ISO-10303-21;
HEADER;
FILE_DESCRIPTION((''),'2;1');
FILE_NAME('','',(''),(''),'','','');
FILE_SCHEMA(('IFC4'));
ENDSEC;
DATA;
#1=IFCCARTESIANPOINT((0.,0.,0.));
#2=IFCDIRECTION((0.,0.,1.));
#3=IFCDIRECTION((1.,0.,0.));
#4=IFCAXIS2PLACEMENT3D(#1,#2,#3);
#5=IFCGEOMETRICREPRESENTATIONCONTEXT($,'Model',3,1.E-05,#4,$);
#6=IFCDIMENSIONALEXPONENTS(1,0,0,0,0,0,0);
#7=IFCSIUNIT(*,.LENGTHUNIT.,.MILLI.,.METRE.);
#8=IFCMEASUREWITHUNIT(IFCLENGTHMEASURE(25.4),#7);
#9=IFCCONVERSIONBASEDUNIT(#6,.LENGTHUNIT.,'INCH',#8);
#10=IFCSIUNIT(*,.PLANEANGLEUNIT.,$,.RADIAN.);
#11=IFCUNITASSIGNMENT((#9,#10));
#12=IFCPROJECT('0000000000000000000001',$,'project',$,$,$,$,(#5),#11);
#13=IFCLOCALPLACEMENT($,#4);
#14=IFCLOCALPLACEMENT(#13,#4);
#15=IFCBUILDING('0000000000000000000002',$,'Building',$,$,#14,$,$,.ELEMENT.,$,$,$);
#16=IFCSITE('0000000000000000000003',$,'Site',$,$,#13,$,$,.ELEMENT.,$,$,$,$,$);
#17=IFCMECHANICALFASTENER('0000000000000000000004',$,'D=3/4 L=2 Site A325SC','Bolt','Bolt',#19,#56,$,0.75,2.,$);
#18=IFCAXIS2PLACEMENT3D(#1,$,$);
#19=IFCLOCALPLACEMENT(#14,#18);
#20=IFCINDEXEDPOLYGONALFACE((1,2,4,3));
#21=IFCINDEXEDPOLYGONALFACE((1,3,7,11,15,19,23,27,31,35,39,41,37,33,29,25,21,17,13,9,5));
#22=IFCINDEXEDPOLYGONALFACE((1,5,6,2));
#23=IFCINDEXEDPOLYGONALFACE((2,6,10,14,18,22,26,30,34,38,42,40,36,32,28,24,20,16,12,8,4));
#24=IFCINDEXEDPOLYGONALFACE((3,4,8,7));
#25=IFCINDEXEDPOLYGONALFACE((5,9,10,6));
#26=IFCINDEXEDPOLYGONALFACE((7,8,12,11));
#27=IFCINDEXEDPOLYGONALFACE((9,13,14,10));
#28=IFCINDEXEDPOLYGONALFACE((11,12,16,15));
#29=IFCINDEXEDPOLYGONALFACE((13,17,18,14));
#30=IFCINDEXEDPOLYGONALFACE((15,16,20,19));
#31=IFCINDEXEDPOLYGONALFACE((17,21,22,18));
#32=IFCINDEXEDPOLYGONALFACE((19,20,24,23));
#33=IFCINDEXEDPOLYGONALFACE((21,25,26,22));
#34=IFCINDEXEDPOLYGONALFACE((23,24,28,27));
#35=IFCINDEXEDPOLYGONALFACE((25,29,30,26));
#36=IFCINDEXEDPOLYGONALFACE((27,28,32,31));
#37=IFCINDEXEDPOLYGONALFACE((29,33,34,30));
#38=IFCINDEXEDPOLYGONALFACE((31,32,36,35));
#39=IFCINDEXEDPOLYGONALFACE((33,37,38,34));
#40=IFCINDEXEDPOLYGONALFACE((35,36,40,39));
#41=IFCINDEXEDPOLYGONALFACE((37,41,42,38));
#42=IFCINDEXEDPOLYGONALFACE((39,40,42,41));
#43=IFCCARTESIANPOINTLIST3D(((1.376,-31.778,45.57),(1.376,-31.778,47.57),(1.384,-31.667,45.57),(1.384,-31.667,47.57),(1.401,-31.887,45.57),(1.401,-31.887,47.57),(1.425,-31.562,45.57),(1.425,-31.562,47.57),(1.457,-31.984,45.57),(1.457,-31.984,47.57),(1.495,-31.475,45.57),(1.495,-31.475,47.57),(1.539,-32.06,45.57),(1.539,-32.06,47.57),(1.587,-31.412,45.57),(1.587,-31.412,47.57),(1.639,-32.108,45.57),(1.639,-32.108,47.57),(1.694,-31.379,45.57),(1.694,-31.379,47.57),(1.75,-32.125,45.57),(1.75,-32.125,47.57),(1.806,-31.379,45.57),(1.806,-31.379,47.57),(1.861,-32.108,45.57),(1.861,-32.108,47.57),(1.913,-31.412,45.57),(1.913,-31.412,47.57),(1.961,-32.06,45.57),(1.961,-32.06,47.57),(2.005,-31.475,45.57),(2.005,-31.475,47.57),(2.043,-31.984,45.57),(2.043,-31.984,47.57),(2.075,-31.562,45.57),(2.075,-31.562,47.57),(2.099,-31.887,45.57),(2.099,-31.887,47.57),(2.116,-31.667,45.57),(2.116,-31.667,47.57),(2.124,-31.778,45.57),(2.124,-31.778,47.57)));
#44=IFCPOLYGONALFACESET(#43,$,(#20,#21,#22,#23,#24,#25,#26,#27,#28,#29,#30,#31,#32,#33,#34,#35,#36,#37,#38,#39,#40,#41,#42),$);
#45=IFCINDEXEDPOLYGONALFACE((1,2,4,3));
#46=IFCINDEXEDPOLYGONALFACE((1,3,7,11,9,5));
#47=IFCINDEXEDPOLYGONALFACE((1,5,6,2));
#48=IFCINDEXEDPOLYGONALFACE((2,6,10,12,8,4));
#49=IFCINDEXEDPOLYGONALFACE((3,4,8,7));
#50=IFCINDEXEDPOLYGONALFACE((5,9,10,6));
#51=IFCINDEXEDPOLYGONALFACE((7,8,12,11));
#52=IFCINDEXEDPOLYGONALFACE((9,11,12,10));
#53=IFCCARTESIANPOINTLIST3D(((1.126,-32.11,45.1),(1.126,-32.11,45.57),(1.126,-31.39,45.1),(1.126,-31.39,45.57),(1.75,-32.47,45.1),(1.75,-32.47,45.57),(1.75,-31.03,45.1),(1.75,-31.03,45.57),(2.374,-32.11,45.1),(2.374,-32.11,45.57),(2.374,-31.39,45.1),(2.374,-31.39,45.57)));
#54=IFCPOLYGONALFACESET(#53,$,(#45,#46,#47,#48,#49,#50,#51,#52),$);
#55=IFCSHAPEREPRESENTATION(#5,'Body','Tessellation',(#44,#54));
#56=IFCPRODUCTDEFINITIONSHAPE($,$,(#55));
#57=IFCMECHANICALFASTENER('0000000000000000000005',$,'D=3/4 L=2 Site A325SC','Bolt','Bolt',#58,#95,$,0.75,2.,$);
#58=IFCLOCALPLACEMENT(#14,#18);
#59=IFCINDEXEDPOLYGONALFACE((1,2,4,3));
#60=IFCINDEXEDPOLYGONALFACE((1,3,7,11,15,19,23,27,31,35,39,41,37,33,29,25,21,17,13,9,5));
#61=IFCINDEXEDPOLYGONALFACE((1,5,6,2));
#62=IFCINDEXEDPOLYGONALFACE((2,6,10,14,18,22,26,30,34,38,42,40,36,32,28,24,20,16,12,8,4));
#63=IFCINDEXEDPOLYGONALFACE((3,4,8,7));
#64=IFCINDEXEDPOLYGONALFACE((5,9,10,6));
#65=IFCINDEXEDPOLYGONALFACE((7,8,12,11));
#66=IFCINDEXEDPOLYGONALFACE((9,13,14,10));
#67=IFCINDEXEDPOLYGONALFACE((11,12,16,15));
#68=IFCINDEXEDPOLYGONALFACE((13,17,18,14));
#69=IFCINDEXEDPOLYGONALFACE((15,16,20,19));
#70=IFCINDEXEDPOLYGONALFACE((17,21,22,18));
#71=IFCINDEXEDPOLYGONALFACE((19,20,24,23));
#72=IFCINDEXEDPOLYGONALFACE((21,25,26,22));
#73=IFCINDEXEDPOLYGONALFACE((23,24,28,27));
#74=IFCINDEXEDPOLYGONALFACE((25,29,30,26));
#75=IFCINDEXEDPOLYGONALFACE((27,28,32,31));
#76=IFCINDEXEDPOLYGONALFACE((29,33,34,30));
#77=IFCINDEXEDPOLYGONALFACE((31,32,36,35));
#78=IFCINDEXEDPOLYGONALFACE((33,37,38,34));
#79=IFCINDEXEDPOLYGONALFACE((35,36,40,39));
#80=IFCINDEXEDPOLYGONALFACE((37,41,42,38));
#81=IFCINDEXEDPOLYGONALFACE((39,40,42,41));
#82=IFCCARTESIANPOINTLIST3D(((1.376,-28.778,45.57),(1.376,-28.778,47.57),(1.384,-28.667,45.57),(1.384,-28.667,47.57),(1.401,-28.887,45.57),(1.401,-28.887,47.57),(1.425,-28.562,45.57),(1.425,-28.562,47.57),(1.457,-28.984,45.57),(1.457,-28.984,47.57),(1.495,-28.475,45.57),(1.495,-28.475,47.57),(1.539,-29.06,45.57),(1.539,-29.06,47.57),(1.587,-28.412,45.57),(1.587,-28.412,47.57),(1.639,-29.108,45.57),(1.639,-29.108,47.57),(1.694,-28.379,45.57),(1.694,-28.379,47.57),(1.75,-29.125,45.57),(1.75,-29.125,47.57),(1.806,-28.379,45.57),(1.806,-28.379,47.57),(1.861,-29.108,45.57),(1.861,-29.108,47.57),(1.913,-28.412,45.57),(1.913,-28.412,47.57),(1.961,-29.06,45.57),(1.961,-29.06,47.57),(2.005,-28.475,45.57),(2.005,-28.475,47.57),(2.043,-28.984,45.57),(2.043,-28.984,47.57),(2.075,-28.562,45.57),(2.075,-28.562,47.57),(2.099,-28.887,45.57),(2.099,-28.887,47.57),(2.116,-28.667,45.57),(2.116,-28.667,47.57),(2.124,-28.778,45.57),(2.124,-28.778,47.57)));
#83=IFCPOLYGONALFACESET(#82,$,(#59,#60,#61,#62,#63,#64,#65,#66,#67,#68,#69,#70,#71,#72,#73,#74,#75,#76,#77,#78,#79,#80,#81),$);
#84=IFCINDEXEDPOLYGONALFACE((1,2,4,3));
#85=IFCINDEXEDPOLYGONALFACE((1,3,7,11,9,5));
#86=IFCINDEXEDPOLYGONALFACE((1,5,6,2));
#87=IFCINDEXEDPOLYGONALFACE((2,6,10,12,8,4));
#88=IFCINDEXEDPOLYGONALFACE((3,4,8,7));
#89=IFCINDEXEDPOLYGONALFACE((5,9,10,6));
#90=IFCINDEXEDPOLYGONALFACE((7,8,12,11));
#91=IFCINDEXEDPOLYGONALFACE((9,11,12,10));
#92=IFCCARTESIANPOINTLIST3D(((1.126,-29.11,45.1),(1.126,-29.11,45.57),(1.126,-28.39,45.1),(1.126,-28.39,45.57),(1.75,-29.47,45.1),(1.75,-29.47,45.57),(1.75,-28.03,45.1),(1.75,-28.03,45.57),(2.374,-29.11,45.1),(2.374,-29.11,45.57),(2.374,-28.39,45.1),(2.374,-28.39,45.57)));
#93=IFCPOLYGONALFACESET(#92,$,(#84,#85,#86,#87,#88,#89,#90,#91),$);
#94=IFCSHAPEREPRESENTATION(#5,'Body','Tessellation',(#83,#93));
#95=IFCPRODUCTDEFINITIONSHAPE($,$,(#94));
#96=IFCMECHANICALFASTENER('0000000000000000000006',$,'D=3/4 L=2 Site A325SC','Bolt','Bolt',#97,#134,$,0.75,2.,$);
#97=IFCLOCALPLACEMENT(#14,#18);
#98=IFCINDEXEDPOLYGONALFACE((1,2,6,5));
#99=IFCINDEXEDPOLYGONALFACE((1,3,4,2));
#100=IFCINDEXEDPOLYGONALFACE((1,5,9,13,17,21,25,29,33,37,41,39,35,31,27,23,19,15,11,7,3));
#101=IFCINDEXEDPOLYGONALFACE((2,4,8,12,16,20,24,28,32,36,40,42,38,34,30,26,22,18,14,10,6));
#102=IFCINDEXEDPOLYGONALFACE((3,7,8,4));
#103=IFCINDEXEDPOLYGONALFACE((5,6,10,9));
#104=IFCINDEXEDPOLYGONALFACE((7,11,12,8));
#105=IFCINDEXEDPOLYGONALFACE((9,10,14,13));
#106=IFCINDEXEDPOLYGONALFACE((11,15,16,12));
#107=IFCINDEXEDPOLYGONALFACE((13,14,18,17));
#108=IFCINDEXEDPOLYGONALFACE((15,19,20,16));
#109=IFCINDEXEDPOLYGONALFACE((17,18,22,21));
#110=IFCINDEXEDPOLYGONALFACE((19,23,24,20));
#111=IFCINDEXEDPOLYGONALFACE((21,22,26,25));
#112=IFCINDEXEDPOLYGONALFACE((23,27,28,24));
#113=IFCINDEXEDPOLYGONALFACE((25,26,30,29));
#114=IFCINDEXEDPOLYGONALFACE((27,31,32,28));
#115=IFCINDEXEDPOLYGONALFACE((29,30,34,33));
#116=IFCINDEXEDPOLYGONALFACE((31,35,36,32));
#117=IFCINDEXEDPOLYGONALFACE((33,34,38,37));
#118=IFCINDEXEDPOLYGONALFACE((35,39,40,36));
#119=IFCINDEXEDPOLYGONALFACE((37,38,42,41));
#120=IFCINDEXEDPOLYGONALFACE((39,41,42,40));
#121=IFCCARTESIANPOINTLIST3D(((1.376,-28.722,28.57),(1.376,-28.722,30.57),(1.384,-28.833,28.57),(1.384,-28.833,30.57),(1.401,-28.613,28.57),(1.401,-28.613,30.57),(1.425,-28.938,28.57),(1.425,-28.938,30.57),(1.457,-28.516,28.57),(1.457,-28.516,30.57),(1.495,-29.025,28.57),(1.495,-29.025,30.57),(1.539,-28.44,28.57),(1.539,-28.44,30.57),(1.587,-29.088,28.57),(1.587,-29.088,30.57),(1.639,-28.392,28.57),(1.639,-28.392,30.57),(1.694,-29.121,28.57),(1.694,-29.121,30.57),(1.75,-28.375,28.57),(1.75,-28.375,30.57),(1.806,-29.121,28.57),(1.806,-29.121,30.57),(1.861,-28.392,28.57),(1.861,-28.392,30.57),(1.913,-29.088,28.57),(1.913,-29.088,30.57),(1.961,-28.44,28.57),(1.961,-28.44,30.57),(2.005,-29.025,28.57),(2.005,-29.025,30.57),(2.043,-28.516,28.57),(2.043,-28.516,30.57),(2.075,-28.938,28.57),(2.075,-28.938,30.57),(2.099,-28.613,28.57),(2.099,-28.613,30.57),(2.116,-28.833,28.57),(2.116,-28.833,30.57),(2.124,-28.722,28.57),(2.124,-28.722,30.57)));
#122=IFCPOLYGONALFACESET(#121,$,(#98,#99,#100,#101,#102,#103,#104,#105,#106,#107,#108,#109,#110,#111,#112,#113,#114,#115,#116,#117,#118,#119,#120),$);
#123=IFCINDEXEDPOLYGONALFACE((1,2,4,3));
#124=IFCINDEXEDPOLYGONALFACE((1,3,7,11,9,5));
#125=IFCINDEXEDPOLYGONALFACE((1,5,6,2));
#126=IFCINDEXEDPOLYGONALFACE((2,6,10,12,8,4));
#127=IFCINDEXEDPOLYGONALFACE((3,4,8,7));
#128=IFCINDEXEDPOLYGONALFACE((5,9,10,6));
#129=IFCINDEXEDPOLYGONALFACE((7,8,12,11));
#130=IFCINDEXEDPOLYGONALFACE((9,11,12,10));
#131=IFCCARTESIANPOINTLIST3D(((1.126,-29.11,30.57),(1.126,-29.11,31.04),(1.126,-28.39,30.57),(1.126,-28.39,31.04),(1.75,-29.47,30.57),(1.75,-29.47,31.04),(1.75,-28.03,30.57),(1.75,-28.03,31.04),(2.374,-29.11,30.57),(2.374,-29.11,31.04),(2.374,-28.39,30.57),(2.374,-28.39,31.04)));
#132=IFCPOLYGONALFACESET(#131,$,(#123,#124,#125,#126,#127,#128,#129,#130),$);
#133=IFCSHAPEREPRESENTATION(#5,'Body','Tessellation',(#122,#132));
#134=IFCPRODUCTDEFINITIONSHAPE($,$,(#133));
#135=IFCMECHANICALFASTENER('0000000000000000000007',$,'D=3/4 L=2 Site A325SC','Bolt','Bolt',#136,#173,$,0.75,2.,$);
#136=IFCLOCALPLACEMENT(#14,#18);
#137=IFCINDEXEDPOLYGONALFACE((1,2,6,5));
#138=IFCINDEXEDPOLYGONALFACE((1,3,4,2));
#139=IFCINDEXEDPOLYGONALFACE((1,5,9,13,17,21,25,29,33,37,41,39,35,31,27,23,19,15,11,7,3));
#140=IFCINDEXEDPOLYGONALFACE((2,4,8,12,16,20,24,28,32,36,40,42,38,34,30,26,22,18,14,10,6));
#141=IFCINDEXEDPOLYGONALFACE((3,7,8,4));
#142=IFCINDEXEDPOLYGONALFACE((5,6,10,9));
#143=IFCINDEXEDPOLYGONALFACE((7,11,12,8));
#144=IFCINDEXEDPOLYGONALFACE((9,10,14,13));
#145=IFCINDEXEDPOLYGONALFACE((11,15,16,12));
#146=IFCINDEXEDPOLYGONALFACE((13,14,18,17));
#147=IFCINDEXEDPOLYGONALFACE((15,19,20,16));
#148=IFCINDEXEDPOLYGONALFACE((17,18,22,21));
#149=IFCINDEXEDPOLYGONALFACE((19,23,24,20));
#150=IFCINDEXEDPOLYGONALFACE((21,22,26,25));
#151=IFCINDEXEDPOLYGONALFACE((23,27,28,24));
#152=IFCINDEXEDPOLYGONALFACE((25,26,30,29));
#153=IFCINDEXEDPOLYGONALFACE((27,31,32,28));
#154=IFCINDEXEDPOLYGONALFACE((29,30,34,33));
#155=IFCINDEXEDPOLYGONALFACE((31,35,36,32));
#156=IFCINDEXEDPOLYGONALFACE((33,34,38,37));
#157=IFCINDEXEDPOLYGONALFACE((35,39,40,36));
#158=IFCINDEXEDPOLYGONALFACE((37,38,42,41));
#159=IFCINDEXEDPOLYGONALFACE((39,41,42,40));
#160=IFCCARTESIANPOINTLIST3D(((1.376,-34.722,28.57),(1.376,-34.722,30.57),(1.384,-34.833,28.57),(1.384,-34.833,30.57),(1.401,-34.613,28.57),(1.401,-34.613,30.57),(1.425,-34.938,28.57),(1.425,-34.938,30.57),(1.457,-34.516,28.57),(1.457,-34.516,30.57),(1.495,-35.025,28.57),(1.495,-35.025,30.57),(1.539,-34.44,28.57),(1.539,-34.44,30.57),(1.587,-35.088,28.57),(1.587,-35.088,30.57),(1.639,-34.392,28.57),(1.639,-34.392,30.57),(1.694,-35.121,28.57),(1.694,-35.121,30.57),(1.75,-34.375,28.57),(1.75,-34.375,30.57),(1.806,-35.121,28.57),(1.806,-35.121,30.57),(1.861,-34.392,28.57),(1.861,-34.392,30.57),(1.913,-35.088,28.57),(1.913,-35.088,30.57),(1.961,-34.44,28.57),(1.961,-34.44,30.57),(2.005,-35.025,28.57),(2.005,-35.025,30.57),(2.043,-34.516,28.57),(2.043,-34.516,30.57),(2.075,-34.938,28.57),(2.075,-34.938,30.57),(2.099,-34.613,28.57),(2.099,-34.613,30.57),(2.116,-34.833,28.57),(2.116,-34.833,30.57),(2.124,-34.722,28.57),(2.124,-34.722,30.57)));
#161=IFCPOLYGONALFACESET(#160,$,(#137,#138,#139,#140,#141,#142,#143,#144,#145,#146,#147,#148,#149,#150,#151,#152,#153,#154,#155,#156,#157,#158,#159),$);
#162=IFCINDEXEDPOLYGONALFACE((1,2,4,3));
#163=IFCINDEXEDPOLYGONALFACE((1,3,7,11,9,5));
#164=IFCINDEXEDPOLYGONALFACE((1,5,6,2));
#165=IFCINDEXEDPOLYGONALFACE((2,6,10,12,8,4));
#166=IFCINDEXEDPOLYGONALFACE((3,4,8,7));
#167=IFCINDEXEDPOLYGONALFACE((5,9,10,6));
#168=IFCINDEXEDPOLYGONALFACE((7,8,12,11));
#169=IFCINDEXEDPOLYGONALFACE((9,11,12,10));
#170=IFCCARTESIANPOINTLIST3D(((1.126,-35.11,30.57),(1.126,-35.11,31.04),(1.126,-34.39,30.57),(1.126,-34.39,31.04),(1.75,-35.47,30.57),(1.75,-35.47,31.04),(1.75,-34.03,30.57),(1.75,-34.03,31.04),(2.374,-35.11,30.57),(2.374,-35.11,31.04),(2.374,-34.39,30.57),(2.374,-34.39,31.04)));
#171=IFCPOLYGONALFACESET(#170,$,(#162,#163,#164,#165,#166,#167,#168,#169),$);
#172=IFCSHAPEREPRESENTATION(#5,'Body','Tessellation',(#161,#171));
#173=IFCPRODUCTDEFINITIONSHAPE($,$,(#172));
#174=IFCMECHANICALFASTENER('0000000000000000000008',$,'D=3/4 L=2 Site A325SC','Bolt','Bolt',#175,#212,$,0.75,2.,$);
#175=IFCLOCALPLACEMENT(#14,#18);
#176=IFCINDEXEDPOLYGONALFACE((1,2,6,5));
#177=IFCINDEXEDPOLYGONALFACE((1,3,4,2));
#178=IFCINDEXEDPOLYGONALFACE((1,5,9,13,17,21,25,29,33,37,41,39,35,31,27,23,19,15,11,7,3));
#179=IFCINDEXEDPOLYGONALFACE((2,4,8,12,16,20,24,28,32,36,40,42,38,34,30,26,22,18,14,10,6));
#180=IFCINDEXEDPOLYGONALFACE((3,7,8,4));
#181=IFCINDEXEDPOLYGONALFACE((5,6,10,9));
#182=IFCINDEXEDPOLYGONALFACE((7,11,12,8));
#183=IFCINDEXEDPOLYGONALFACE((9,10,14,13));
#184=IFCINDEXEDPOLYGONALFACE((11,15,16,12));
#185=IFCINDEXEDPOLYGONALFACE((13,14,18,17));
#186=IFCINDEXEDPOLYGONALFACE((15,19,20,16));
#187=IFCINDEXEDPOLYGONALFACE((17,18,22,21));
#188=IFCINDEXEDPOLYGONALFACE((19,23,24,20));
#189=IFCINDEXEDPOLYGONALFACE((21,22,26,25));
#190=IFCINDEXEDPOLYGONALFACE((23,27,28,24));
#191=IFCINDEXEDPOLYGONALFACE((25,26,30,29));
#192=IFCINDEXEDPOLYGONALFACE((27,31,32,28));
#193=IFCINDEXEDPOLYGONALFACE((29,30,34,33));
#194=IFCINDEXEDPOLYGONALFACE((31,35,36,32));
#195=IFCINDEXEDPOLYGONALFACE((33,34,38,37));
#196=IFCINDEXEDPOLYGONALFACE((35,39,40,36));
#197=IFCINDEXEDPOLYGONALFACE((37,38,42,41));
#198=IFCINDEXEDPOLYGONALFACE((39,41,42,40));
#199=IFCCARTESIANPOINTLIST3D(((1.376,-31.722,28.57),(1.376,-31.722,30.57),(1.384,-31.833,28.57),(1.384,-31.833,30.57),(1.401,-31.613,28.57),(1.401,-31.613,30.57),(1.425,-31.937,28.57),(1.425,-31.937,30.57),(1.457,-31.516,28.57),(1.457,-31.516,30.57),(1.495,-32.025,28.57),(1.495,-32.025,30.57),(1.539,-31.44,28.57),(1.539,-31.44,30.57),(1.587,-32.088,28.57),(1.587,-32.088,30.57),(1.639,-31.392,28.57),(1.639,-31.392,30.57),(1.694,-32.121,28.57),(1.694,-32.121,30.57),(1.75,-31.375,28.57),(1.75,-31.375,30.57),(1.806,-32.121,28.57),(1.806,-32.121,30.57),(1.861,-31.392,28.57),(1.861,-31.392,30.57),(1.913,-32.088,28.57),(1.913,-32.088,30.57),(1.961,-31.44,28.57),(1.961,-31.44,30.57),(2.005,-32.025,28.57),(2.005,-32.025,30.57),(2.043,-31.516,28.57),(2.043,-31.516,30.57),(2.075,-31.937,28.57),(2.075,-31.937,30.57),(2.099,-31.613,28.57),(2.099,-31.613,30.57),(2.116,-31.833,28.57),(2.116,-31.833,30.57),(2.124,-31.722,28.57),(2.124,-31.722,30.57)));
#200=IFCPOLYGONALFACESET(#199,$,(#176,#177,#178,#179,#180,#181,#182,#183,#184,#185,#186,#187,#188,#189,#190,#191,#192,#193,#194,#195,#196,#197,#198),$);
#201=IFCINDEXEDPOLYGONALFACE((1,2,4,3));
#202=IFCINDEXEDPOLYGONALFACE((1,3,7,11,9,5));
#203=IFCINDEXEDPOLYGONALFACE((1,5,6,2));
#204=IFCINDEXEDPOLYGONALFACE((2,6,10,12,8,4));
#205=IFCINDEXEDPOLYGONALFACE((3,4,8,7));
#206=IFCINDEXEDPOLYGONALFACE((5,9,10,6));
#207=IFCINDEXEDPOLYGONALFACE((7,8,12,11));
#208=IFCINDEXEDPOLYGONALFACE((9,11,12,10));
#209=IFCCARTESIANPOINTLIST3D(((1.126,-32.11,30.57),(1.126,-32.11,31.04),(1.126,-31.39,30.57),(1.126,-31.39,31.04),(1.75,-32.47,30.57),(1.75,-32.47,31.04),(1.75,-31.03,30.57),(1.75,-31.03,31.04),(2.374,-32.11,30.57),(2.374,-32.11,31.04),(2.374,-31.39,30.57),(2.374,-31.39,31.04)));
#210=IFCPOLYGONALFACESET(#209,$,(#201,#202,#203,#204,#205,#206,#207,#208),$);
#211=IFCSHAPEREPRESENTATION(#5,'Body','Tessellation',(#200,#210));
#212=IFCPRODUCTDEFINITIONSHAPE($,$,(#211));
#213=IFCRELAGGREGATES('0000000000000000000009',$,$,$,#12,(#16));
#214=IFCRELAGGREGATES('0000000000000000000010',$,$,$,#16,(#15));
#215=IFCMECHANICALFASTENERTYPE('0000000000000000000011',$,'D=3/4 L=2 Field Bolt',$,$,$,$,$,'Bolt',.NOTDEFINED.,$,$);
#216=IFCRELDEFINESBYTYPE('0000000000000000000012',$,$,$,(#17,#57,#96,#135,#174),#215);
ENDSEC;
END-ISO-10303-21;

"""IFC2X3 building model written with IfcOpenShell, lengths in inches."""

from ifc_helpers import new_model, entity, si_unit, converted_unit, frame, origin_with_axes, origin_2d_with_axis, place, context, project, spatial, polyline, circle, outline, extrude, source, transform, mapped, type_object, type_shapes, element, save


model = new_model("IFC2X3")

# Units and contexts
model_context = context("Model", 3, precision=1e-05, world=origin_with_axes())
ifc_project = project(units=[converted_unit("LENGTHUNIT", "INCH", entity("IfcLengthMeasure", 25.4), si_unit("LENGTHUNIT", "METRE", prefix="MILLI"), dimensions=[1, 0, 0, 0, 0, 0, 0]), si_unit("PLANEANGLEUNIT", "RADIAN")], contexts=[model_context])

# Site, building
site_placement = place(None, origin_with_axes())
site = spatial("IfcSite", under=ifc_project, at=site_placement, Name="Site", CompositionType="ELEMENT")
building_placement = place(site_placement, origin_with_axes())
building = spatial("IfcBuilding", under=site, at=building_placement, Name="Building", CompositionType="ELEMENT")

# Mechanical fasteners
placement_1 = place(building_placement, frame((0.0, 0.0, 46.0), z_axis=(0.0, 0.0, 1.0), x_axis=(0.0, -1.0, 0.0)))
mechanical_fastener_type_1 = type_object("IfcMechanicalFastenerType", Name="D=3/4 L=2 Field Bolt", ElementType="Bolt")
shared_shape_1 = source(origin_with_axes(), model_context, "Body", "SweptSolid", [
    extrude(circle(Radius=0.375, at=origin_2d_with_axis()), frame((0.0, 0.0, 0.0), z_axis=(1.0, 0.0, 0.0), x_axis=(0.0, 1.0, 0.0)), (0.0, 0.0, 1.0), 2.0),
    extrude(outline(polyline([(-0.72, 0.0), (-0.36, 0.624), (0.36, 0.624), (0.72, 0.0), (0.36, -0.624), (-0.36, -0.624), (-0.72, 0.0)])), frame((0.0, 0.0, 0.0), z_axis=(1.0, 0.0, 0.0), x_axis=(0.0, 1.0, 0.0)), (0.0, 0.0, -1.0), 0.47),
])
type_shapes(mechanical_fastener_type_1, [shared_shape_1])
placement_2 = place(placement_1, frame((28.75, -1.75, -0.43), z_axis=(0.0, 1.0, 0.0), x_axis=(0.0, 0.0, 1.0)))
for number, where, z_axis, x_axis, name in (
    (1, (0.0, 3.0, 3.5), (0.0, 0.0, 1.0), (1.0, 0.0, 0.0), "D=3/4 L=2 Site A325SC"),
    (2, (0.0, 0.0, 3.5), (0.0, 0.0, 1.0), (1.0, 0.0, 0.0), "D=3/4 L=2 Site A325SC"),
):
    element("IfcMechanicalFastener", number, at=place(placement_2, frame(where, z_axis=z_axis, x_axis=x_axis)), type_object=mechanical_fastener_type_1, Name=name, Description="Bolt", ObjectType="Bolt", NominalDiameter=0.75, NominalLength=2.0, context=model_context, shape_type="MappedRepresentation", body=[
        mapped(shared_shape_1, transform((0.0, 0.0, 0.0), scale=1.0)),
    ])
placement_3 = place(placement_1, frame((28.75, -1.75, -15.43), z_axis=(0.0, 1.0, 0.0), x_axis=(0.0, 0.0, -1.0)))
for number, where, z_axis, x_axis, name in (
    (3, (0.0, 0.0, 3.5), (0.0, 0.0, 1.0), (1.0, 0.0, 0.0), "D=3/4 L=2 Site A325SC"),
    (4, (0.0, -6.0, 3.5), (0.0, 0.0, 1.0), (1.0, 0.0, 0.0), "D=3/4 L=2 Site A325SC"),
    (5, (0.0, -3.0, 3.5), (0.0, 0.0, 1.0), (1.0, 0.0, 0.0), "D=3/4 L=2 Site A325SC"),
):
    element("IfcMechanicalFastener", number, at=place(placement_3, frame(where, z_axis=z_axis, x_axis=x_axis)), type_object=mechanical_fastener_type_1, Name=name, Description="Bolt", ObjectType="Bolt", NominalDiameter=0.75, NominalLength=2.0, context=model_context, shape_type="MappedRepresentation", body=[
        mapped(shared_shape_1, transform((0.0, 0.0, 0.0), scale=1.0)),
    ])

save(model, "model.ifc")
